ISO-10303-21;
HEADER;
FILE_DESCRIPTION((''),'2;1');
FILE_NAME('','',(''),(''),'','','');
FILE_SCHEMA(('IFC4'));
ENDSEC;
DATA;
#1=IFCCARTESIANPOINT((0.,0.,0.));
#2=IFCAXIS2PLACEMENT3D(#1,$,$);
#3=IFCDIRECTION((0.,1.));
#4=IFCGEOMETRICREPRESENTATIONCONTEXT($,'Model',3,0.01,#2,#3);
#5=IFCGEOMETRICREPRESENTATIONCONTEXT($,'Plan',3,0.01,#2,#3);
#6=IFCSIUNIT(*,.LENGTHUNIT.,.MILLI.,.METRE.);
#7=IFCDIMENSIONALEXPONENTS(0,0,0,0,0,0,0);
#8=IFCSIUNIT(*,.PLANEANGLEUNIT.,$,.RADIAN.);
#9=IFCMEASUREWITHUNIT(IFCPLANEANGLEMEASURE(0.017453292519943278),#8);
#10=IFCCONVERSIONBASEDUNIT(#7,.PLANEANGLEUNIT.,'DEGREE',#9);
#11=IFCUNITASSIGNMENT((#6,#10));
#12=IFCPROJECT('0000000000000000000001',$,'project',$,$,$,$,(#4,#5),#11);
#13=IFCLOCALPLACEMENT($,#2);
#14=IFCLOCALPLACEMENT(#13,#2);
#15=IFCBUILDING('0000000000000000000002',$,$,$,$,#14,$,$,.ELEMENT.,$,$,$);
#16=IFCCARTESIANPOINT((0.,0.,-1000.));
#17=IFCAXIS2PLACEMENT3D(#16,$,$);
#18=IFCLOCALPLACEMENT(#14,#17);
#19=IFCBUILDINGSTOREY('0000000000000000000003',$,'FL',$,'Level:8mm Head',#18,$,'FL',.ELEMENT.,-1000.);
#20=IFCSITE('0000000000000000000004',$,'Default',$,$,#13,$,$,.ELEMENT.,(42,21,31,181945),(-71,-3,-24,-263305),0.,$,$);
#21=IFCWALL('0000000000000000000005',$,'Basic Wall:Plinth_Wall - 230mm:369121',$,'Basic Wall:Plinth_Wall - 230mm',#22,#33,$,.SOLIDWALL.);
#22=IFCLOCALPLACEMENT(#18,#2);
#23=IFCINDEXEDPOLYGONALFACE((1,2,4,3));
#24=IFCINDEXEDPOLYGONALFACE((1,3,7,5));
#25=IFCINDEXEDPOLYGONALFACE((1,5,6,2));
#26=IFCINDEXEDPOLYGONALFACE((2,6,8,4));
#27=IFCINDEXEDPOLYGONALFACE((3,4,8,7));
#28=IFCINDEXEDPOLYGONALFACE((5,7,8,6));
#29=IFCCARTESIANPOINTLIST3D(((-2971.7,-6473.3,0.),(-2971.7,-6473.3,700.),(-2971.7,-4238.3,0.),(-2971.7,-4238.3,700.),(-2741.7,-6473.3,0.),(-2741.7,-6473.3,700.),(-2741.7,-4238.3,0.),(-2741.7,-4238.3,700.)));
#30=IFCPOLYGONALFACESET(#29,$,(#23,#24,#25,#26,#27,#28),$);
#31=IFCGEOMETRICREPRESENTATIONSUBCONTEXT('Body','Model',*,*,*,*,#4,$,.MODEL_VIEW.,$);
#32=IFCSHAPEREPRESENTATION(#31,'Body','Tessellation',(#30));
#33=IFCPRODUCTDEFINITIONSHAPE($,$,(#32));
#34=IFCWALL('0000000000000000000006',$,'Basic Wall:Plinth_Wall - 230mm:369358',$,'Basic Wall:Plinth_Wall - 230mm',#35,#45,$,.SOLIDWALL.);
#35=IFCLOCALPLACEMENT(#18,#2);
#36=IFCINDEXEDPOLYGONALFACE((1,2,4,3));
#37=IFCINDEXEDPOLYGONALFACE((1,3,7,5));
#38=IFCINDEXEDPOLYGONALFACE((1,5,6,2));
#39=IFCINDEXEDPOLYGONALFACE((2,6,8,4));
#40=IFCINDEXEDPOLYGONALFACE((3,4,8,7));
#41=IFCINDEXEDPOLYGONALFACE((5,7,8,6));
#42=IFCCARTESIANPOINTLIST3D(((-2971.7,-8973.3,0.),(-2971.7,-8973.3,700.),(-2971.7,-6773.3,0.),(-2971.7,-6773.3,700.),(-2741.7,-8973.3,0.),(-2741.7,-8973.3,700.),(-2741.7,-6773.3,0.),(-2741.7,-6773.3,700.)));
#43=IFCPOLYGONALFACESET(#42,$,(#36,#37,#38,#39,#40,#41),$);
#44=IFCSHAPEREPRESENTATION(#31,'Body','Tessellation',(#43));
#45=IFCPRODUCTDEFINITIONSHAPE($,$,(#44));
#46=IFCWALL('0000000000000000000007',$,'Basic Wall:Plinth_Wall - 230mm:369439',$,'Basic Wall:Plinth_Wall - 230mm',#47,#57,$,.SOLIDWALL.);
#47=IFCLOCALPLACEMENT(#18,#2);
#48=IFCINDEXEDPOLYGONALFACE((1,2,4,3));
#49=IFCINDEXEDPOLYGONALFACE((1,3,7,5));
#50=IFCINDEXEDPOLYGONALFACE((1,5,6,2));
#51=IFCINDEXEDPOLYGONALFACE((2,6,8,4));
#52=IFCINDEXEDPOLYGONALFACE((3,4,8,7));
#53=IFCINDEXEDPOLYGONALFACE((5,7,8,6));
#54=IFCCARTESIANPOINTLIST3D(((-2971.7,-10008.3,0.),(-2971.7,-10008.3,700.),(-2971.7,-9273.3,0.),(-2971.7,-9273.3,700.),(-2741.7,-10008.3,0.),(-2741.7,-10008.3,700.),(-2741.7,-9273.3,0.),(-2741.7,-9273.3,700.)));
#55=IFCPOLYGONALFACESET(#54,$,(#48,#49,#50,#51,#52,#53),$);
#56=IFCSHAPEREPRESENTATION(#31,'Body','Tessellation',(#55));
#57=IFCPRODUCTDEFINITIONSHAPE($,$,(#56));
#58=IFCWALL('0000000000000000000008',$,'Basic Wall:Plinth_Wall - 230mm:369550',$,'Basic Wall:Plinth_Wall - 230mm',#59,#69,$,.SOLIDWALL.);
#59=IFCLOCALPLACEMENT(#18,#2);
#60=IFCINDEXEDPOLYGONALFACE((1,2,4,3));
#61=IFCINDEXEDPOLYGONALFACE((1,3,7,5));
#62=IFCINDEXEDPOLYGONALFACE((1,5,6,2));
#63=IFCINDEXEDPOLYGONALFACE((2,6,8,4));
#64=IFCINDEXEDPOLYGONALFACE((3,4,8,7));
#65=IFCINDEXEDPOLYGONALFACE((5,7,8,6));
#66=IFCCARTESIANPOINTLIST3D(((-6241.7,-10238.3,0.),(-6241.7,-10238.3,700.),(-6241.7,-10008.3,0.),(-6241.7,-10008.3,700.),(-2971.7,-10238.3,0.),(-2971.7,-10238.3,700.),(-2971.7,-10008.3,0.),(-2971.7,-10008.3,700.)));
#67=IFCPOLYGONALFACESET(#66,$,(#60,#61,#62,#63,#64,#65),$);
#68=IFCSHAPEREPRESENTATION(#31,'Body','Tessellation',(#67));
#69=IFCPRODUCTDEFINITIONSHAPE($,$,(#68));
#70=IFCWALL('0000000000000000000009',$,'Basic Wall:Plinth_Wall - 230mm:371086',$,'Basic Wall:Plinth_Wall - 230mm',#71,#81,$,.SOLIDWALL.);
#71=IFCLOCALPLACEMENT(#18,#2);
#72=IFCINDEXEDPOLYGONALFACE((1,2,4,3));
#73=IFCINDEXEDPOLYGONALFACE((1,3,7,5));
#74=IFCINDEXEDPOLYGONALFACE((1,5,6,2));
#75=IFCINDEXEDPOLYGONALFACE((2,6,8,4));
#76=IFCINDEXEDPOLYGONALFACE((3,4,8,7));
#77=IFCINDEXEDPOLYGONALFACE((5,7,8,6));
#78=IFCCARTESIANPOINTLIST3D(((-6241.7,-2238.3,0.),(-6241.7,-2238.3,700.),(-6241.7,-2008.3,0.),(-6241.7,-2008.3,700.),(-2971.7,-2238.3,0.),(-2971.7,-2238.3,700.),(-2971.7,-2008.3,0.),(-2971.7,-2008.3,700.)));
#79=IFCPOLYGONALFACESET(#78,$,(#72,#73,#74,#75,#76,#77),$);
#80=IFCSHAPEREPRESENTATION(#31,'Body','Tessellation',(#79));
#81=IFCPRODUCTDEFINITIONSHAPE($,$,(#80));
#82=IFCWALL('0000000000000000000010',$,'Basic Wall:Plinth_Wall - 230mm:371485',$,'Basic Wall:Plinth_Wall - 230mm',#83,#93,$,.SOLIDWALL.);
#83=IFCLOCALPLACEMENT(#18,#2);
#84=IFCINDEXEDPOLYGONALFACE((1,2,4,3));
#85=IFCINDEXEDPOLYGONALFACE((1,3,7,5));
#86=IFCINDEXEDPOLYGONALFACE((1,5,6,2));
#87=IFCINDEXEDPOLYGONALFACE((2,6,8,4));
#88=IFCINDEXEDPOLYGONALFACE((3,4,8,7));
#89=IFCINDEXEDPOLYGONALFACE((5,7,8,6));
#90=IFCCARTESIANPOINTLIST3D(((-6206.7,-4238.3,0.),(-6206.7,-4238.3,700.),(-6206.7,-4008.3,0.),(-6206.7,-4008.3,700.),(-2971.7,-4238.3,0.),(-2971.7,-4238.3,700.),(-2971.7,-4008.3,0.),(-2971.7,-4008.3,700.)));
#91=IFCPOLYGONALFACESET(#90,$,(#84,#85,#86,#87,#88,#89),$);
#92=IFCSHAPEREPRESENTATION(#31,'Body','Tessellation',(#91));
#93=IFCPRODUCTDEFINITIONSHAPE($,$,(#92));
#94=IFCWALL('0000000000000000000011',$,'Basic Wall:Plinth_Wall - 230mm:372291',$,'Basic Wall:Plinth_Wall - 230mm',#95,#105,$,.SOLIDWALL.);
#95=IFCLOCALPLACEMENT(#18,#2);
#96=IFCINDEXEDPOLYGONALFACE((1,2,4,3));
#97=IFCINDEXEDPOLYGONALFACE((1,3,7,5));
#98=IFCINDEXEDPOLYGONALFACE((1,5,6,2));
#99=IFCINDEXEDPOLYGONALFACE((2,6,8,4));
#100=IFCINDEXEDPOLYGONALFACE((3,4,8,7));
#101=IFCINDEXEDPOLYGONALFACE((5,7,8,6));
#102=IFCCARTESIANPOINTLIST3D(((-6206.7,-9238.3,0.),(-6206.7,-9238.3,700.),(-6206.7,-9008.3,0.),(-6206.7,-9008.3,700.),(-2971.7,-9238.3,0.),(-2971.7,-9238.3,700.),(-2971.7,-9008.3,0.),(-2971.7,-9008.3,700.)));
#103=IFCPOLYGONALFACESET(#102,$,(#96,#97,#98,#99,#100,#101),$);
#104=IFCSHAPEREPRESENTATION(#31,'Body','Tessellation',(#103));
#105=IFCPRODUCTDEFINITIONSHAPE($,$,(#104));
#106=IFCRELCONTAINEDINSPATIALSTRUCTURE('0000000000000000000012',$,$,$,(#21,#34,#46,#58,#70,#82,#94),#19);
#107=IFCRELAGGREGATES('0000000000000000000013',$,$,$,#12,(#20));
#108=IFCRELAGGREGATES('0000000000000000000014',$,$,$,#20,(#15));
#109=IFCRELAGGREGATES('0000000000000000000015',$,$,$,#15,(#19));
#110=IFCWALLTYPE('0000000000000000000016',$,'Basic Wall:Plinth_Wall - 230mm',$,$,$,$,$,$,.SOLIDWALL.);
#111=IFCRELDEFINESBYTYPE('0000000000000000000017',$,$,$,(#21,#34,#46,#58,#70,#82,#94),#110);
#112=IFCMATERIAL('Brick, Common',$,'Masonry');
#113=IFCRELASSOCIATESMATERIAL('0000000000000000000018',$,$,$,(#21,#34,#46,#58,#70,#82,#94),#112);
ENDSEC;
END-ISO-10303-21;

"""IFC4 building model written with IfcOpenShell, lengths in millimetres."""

from ifc_helpers import new_model, entity, si_unit, converted_unit, direction, frame, origin, place, context, subcontext, project, spatial, indexed_curve, outline, extrude, material, type_object, element, save


model = new_model("IFC4")

# Units and contexts
model_context = context("Model", 3, precision=0.01, world=origin(), true_north=direction((0.0, 1.0)))
plan_context = context("Plan", 3, precision=0.01, world=origin(), true_north=direction((0.0, 1.0)))
body_context = subcontext(model_context, "Body", "Model", "MODEL_VIEW")
ifc_project = project(units=[si_unit("LENGTHUNIT", "METRE", prefix="MILLI"), converted_unit("PLANEANGLEUNIT", "DEGREE", entity("IfcPlaneAngleMeasure", 0.017453292519943278), si_unit("PLANEANGLEUNIT", "RADIAN"), dimensions=[0, 0, 0, 0, 0, 0, 0])], contexts=[model_context, plan_context])

# Site, building, storey
site_placement = place(None, origin())
site = spatial("IfcSite", under=ifc_project, at=site_placement, Name="Default", CompositionType="ELEMENT", RefLatitude=(42, 21, 31, 181945), RefLongitude=(-71, -3, -24, -263305), RefElevation=0.0)
building_placement = place(site_placement, origin())
building = spatial("IfcBuilding", under=site, at=building_placement, CompositionType="ELEMENT")
storey_placement = place(building_placement, frame((0.0, 0.0, -1000.0)))
storey = spatial("IfcBuildingStorey", under=building, at=storey_placement, Name="FL", ObjectType="Level:8mm Head", LongName="FL", CompositionType="ELEMENT", Elevation=-1000.0)

# Walls
ifc_material_1 = material(Name="Brick, Common", Category="Masonry")
wall_type = type_object("IfcWallType", Name="Basic Wall:Plinth_Wall - 230mm", PredefinedType="SOLIDWALL")
wall_1_placement = place(storey_placement, frame((-2856.7, -4238.3, 0.0), z_axis=(0.0, 0.0, 1.0), x_axis=(0.0, -1.0, 0.0)))
element("IfcWall", 1, at=wall_1_placement, inside=storey, type_object=wall_type, material=ifc_material_1, Name="Basic Wall:Plinth_Wall - 230mm:369121", ObjectType="Basic Wall:Plinth_Wall - 230mm", PredefinedType="SOLIDWALL", context=body_context, shape_type="SweptSolid", body=[
    extrude(outline(indexed_curve([(2235.0, 115.0), (0.0, 115.0), (0.0, -115.0), (2235.0, -115.0), (2235.0, 115.0)], self_intersect=False)), origin(), (0.0, 0.0, 1.0), 700.0),
])
wall_2_placement = place(storey_placement, frame((-2856.7, -6773.3, 0.0), z_axis=(0.0, 0.0, 1.0), x_axis=(0.0, -1.0, 0.0)))
element("IfcWall", 2, at=wall_2_placement, inside=storey, type_object=wall_type, material=ifc_material_1, Name="Basic Wall:Plinth_Wall - 230mm:369358", ObjectType="Basic Wall:Plinth_Wall - 230mm", PredefinedType="SOLIDWALL", context=body_context, shape_type="SweptSolid", body=[
    extrude(outline(indexed_curve([(2200.0, 115.0), (0.0, 115.0), (0.0, -115.0), (2200.0, -115.0), (2200.0, 115.0)], self_intersect=False)), origin(), (0.0, 0.0, 1.0), 700.0),
])
wall_3_placement = place(storey_placement, frame((-2856.7, -9273.3, 0.0), z_axis=(0.0, 0.0, 1.0), x_axis=(0.0, -1.0, 0.0)))
element("IfcWall", 3, at=wall_3_placement, inside=storey, type_object=wall_type, material=ifc_material_1, Name="Basic Wall:Plinth_Wall - 230mm:369439", ObjectType="Basic Wall:Plinth_Wall - 230mm", PredefinedType="SOLIDWALL", context=body_context, shape_type="SweptSolid", body=[
    extrude(outline(indexed_curve([(735.0, 115.0), (0.0, 115.0), (0.0, -115.0), (735.0, -115.0), (735.0, 115.0)], self_intersect=False)), origin(), (0.0, 0.0, 1.0), 700.0),
])
wall_4_placement = place(storey_placement, frame((-2971.7, -10123.3, 0.0), z_axis=(0.0, 0.0, 1.0), x_axis=(-1.0, 0.0, 0.0)))
element("IfcWall", 4, at=wall_4_placement, inside=storey, type_object=wall_type, material=ifc_material_1, Name="Basic Wall:Plinth_Wall - 230mm:369550", ObjectType="Basic Wall:Plinth_Wall - 230mm", PredefinedType="SOLIDWALL", context=body_context, shape_type="SweptSolid", body=[
    extrude(outline(indexed_curve([(3270.0, 115.0), (0.0, 115.0), (0.0, -115.0), (3270.0, -115.0), (3270.0, 115.0)], self_intersect=False)), origin(), (0.0, 0.0, 1.0), 700.0),
])
wall_5_placement = place(storey_placement, frame((-6241.7, -2123.3, 0.0)))
element("IfcWall", 5, at=wall_5_placement, inside=storey, type_object=wall_type, material=ifc_material_1, Name="Basic Wall:Plinth_Wall - 230mm:371086", ObjectType="Basic Wall:Plinth_Wall - 230mm", PredefinedType="SOLIDWALL", context=body_context, shape_type="SweptSolid", body=[
    extrude(outline(indexed_curve([(3270.0, 115.0), (0.0, 115.0), (0.0, -115.0), (3270.0, -115.0), (3270.0, 115.0)], self_intersect=False)), origin(), (0.0, 0.0, 1.0), 700.0),
])
wall_6_placement = place(storey_placement, frame((-6206.7, -4123.3, 0.0)))
element("IfcWall", 6, at=wall_6_placement, inside=storey, type_object=wall_type, material=ifc_material_1, Name="Basic Wall:Plinth_Wall - 230mm:371485", ObjectType="Basic Wall:Plinth_Wall - 230mm", PredefinedType="SOLIDWALL", context=body_context, shape_type="SweptSolid", body=[
    extrude(outline(indexed_curve([(3235.0, 115.0), (0.0, 115.0), (0.0, -115.0), (3235.0, -115.0), (3235.0, 115.0)], self_intersect=False)), origin(), (0.0, 0.0, 1.0), 700.0),
])
wall_7_placement = place(storey_placement, frame((-6206.7, -9123.3, 0.0)))
element("IfcWall", 7, at=wall_7_placement, inside=storey, type_object=wall_type, material=ifc_material_1, Name="Basic Wall:Plinth_Wall - 230mm:372291", ObjectType="Basic Wall:Plinth_Wall - 230mm", PredefinedType="SOLIDWALL", context=body_context, shape_type="SweptSolid", body=[
    extrude(outline(indexed_curve([(3235.0, 115.0), (0.0, 115.0), (0.0, -115.0), (3235.0, -115.0), (3235.0, 115.0)], self_intersect=False)), origin(), (0.0, 0.0, 1.0), 700.0),
])

save(model, "model.ifc")
